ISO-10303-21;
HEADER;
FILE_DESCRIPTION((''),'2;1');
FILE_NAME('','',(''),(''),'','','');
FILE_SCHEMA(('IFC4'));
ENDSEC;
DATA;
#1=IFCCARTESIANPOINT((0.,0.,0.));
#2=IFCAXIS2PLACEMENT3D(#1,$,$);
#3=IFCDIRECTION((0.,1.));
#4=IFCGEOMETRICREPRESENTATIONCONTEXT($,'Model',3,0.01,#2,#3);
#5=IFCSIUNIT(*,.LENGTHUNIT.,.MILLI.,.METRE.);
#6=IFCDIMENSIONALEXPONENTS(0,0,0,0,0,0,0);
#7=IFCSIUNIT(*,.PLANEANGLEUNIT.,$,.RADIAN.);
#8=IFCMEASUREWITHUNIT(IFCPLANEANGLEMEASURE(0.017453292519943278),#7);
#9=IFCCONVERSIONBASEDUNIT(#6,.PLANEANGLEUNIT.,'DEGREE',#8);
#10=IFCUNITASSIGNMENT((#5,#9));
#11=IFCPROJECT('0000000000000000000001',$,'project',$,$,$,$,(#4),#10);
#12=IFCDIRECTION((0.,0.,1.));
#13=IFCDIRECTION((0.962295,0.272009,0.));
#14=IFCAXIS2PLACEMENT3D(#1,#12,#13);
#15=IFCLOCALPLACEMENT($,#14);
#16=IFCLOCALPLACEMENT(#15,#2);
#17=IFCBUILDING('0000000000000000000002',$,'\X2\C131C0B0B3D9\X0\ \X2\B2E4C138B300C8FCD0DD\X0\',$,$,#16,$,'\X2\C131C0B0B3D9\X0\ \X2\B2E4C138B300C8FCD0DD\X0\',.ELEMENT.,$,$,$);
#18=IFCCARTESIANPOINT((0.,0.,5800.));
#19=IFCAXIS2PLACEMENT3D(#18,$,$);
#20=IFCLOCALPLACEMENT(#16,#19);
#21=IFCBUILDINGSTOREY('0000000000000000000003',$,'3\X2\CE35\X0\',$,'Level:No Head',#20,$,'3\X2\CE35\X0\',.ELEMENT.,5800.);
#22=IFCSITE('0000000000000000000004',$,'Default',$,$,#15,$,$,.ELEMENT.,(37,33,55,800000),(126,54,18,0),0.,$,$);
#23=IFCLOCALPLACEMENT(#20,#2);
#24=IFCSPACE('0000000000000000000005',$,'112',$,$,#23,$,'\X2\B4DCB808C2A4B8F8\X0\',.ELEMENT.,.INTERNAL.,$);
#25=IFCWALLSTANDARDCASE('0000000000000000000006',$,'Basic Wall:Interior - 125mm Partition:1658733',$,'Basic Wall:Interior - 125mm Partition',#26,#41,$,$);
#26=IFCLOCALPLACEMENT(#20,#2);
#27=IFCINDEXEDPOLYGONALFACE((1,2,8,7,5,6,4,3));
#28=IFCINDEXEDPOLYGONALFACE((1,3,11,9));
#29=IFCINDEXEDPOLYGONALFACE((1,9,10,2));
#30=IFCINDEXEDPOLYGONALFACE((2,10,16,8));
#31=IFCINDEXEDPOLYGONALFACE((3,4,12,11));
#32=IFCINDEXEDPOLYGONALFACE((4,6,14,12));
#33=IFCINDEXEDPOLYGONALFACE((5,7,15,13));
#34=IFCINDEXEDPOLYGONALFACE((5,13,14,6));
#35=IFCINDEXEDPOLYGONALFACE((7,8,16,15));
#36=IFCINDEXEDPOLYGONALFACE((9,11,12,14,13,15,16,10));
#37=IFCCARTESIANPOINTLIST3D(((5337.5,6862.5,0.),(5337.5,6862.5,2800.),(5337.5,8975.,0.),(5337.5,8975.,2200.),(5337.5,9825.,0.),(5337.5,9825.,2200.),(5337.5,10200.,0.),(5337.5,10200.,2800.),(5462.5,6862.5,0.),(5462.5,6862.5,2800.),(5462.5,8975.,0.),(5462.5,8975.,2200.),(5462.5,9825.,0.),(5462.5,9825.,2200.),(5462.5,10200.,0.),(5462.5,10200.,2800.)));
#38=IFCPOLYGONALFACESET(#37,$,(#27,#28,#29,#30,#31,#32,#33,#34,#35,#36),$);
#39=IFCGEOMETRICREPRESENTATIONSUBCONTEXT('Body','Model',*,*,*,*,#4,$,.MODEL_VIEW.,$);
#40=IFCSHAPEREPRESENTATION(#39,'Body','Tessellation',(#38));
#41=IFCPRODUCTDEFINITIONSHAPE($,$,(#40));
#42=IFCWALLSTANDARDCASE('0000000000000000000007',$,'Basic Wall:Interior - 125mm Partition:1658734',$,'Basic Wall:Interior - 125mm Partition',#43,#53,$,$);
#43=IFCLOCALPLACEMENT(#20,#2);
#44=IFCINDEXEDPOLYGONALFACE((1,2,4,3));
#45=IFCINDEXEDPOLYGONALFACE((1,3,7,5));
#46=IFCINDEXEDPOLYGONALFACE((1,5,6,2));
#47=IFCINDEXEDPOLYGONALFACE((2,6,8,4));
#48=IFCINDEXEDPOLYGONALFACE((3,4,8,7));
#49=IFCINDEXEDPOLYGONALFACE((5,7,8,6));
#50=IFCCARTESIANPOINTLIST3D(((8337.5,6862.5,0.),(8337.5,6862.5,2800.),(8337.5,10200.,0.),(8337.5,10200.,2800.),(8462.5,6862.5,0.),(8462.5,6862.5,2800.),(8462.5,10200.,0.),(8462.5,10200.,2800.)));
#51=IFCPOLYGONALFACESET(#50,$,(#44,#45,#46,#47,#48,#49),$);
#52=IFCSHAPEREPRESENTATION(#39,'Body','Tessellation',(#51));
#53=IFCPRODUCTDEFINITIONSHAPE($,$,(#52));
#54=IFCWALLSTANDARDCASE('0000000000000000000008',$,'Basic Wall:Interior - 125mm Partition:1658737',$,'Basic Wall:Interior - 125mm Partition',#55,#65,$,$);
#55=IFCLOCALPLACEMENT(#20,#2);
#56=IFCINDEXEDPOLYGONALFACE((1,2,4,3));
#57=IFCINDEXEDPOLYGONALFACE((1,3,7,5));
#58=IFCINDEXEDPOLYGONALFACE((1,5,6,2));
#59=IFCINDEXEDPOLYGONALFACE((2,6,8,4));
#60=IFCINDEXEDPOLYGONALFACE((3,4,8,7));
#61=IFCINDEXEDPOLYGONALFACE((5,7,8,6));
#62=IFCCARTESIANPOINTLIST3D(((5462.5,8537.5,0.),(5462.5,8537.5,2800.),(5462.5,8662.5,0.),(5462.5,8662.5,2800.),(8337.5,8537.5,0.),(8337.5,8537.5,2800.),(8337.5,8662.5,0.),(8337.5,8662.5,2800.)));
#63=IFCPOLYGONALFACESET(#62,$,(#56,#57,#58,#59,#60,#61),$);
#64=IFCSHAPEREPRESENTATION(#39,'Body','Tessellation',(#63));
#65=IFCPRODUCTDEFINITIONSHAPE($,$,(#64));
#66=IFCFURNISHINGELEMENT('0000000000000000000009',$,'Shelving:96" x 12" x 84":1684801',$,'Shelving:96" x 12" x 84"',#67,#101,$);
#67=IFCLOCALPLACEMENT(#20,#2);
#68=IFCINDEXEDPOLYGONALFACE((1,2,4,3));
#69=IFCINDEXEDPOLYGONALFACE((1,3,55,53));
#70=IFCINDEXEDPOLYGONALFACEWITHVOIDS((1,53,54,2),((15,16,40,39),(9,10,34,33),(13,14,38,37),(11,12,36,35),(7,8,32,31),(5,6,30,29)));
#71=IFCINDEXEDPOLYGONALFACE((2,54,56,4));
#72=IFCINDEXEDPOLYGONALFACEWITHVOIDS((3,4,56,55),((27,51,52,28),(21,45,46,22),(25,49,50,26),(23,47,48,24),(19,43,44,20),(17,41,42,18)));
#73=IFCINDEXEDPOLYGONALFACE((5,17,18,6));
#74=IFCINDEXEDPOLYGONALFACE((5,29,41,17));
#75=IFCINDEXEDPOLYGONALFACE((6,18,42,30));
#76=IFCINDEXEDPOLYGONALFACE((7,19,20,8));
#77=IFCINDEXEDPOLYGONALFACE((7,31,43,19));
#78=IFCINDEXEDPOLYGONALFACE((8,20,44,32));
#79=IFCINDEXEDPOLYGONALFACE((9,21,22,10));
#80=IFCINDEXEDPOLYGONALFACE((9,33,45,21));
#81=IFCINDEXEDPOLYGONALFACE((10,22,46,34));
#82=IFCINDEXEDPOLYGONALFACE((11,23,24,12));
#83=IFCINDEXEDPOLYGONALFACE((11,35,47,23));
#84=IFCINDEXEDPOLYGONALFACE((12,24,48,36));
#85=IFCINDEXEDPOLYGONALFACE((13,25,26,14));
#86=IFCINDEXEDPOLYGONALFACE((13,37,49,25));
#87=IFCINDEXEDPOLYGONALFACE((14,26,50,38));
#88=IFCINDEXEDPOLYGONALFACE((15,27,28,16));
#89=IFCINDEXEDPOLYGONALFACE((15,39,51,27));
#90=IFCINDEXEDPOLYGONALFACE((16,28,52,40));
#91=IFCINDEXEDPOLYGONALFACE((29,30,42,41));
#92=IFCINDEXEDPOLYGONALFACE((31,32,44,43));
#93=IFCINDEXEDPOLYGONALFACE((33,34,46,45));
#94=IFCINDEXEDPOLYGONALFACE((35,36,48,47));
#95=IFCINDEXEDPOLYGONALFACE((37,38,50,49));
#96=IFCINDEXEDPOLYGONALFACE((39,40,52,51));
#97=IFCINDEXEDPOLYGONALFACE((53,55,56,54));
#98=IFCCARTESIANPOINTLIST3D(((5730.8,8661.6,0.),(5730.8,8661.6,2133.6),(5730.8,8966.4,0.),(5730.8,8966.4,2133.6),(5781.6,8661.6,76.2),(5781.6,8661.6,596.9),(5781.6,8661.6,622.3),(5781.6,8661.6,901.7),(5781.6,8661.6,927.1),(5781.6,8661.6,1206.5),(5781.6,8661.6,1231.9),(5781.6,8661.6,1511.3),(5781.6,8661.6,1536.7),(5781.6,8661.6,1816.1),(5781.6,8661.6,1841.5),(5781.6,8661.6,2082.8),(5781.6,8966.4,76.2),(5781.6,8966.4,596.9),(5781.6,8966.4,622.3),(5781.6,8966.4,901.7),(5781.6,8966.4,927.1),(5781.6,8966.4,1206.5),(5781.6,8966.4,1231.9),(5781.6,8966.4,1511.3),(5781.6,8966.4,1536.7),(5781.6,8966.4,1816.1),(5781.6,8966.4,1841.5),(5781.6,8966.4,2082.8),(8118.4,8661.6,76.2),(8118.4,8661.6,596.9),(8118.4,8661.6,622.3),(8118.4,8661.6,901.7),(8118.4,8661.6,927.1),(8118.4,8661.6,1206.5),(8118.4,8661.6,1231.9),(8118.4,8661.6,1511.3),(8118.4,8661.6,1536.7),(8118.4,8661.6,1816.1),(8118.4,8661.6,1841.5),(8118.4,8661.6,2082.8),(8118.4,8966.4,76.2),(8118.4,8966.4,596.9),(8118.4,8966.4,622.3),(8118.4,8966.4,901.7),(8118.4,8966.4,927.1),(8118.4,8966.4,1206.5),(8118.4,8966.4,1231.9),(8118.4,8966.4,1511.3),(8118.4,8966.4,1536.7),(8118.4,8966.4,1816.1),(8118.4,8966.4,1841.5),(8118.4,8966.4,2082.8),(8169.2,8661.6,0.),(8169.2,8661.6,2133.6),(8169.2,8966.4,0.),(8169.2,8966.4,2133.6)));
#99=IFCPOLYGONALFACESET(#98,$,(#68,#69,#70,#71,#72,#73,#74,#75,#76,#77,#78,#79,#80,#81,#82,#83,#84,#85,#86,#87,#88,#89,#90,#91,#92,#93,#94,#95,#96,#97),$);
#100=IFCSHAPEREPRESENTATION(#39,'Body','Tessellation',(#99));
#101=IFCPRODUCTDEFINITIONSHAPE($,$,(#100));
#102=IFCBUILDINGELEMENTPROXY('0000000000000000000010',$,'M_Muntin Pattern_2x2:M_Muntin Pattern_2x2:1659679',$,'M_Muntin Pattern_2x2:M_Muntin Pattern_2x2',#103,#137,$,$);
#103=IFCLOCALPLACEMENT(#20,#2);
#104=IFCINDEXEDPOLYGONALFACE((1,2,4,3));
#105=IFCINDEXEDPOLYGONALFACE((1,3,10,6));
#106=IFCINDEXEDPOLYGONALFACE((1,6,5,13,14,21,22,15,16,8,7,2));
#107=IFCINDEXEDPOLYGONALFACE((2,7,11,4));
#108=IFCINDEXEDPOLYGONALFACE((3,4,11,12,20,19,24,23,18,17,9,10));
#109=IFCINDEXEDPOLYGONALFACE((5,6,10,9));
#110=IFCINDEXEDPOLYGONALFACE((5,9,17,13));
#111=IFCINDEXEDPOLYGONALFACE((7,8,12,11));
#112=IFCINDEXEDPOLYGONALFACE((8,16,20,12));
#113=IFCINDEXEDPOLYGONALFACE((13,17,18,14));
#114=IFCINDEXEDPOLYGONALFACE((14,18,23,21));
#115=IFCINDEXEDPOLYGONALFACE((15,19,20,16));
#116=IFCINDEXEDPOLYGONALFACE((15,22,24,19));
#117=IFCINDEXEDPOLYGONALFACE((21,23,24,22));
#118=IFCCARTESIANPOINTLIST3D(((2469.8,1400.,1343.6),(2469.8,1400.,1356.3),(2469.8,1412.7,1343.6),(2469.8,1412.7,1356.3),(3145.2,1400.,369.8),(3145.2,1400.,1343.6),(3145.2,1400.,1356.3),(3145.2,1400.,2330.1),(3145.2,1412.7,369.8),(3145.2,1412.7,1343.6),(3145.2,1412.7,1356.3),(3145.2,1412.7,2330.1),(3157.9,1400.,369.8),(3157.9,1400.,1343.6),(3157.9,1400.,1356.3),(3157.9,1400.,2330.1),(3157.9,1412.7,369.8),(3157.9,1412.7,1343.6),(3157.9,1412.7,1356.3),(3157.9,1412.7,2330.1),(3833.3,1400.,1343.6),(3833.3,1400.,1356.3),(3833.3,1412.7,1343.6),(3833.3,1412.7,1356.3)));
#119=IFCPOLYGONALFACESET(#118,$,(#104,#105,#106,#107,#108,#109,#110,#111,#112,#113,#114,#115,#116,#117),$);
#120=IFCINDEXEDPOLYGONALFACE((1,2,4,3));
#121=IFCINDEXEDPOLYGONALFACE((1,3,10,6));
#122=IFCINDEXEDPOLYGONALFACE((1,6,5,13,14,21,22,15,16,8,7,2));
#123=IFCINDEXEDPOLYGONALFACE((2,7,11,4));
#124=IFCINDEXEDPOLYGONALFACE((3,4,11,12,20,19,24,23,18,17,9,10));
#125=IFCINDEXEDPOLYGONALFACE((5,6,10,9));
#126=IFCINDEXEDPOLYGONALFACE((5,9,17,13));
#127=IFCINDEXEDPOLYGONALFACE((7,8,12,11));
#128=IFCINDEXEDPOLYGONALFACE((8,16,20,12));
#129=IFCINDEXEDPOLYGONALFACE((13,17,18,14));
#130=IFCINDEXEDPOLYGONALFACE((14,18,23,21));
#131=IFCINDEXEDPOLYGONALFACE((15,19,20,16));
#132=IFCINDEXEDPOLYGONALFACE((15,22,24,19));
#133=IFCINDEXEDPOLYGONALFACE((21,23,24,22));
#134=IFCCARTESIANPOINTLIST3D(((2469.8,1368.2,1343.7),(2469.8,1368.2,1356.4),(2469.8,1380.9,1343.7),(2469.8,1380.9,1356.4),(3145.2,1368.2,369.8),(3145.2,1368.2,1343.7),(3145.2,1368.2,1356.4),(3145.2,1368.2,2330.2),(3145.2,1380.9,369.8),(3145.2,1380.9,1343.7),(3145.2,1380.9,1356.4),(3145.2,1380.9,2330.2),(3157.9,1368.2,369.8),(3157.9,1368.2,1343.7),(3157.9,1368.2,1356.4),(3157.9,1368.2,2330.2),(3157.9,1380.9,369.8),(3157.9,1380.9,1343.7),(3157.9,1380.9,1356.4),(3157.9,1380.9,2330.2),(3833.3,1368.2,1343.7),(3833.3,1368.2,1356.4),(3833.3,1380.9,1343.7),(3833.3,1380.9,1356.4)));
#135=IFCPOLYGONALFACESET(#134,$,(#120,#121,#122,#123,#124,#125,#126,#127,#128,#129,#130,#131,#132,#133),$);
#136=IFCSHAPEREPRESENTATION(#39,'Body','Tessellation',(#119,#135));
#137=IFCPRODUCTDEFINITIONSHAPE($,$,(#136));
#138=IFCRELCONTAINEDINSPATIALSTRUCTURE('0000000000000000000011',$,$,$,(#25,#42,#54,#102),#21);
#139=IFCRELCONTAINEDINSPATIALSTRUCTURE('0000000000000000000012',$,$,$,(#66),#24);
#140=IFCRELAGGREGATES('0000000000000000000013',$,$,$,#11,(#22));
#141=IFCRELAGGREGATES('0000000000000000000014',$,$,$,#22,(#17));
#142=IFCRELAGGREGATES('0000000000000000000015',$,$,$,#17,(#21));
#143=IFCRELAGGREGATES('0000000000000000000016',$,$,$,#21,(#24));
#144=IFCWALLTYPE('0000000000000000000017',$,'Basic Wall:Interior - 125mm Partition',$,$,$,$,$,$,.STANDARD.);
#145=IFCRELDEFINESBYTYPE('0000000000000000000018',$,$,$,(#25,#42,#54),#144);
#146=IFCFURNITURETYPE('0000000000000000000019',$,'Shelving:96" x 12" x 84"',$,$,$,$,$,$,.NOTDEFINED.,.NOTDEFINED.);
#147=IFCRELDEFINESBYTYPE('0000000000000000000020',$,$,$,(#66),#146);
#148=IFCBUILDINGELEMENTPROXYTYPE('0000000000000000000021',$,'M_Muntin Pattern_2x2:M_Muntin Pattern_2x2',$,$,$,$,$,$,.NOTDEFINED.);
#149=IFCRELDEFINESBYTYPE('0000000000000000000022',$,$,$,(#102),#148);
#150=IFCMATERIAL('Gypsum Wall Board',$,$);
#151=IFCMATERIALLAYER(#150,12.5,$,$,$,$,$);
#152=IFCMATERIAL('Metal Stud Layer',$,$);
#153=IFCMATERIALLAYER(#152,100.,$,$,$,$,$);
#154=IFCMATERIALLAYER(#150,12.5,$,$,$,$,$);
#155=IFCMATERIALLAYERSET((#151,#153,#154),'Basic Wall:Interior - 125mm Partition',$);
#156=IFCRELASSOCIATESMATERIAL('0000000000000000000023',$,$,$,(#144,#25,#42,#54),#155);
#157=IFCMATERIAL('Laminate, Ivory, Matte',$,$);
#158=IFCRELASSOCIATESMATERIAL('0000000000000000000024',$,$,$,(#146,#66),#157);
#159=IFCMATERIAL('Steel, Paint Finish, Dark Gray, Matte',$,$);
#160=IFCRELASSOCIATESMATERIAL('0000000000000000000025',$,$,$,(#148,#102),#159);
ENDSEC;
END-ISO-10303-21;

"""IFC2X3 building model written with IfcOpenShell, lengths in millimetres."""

from ifc_helpers import new_model, entity, si_unit, converted_unit, direction, frame, frame_2d, origin, place, context, subcontext, project, spatial, polyline, rectangle, outline, extrude, source, transform, mapped, material, layer, layer_set, layer_usage, type_object, type_shapes, element, save


model = new_model("IFC2X3")

# Units and contexts
model_context = context("Model", 3, precision=0.01, world=origin(), true_north=direction((0.0, 1.0)))
body_context = subcontext(model_context, "Body", "Model", "MODEL_VIEW")
ifc_project = project(units=[si_unit("LENGTHUNIT", "METRE", prefix="MILLI"), converted_unit("PLANEANGLEUNIT", "DEGREE", entity("IfcPlaneAngleMeasure", 0.017453292519943278), si_unit("PLANEANGLEUNIT", "RADIAN"), dimensions=[0, 0, 0, 0, 0, 0, 0])], contexts=[model_context])

# Site, building, storey
site_placement = place(None, frame((0.0, 0.0, 0.0), z_axis=(0.0, 0.0, 1.0), x_axis=(0.962295, 0.272009, 0.0)))
site = spatial("IfcSite", under=ifc_project, at=site_placement, Name="Default", CompositionType="ELEMENT", RefLatitude=(37, 33, 55, 800000), RefLongitude=(126, 54, 18, 0), RefElevation=0.0)
building_placement = place(site_placement, origin())
building = spatial("IfcBuilding", under=site, at=building_placement, Name="성산동 다세대주택", LongName="성산동 다세대주택", CompositionType="ELEMENT")
storey_placement = place(building_placement, frame((0.0, 0.0, 5800.0)))
storey = spatial("IfcBuildingStorey", under=building, at=storey_placement, Name="3층", ObjectType="Level:No Head", LongName="3층", CompositionType="ELEMENT", Elevation=5800.0)

# Wall, opening
ifc_material_1 = material(Name="Gypsum Wall Board")
ifc_layer_1 = layer(ifc_material_1, 12.5)
ifc_material_2 = material(Name="Metal Stud Layer")
ifc_layer_2 = layer(ifc_material_2, 100.0)
ifc_layer_3 = layer(ifc_material_1, 12.5)
ifc_layer_set = layer_set([ifc_layer_1, ifc_layer_2, ifc_layer_3], Name="Basic Wall:Interior - 125mm Partition")
ifc_layer_usage_1 = layer_usage(ifc_layer_set, "AXIS2", "NEGATIVE", 62.5)
wall_type = type_object("IfcWallType", Name="Basic Wall:Interior - 125mm Partition", PredefinedType="STANDARD", material=ifc_layer_set)
wall_1_placement = place(storey_placement, frame((5400.0, 6862.5, 0.0), z_axis=(0.0, 0.0, 1.0), x_axis=(0.0, 1.0, 0.0)))
wall_1 = element("IfcWallStandardCase", 1, at=wall_1_placement, inside=storey, type_object=wall_type, material=ifc_layer_usage_1, Name="Basic Wall:Interior - 125mm Partition:1658733", ObjectType="Basic Wall:Interior - 125mm Partition", context=body_context, shape_type="SweptSolid", body=[
    extrude(rectangle(XDim=3337.5, YDim=125.0, at=frame_2d((1668.7, 0.0), x_axis=(1.0, 0.0))), origin(), (0.0, 0.0, 1.0), 2800.0),
])
opening_placement = place(wall_1_placement, frame((2112.5, -62.5, 0.0)))
element("IfcOpeningElement", 2, at=opening_placement, cuts=wall_1, ObjectType="Opening", context=body_context, shape_type="SweptSolid", body=[
    extrude(rectangle(XDim=2200.0, YDim=850.0, at=frame_2d((1100.0, 425.0), x_axis=(1.0, 0.0))), frame((0.0, 0.0, 0.0), z_axis=(0.0, 1.0, 0.0), x_axis=(0.0, 0.0, 1.0)), (0.0, 0.0, 1.0), 125.0),
])

# Walls
ifc_layer_usage_2 = layer_usage(ifc_layer_set, "AXIS2", "NEGATIVE", 62.5)
wall_2_placement = place(storey_placement, frame((8400.0, 6862.5, 0.0), z_axis=(0.0, 0.0, 1.0), x_axis=(0.0, 1.0, 0.0)))
element("IfcWallStandardCase", 3, at=wall_2_placement, inside=storey, type_object=wall_type, material=ifc_layer_usage_2, Name="Basic Wall:Interior - 125mm Partition:1658734", ObjectType="Basic Wall:Interior - 125mm Partition", context=body_context, shape_type="SweptSolid", body=[
    extrude(rectangle(XDim=3337.5, YDim=125.0, at=frame_2d((1668.7, 0.0), x_axis=(-1.0, 0.0))), origin(), (0.0, 0.0, 1.0), 2800.0),
])
ifc_layer_usage_3 = layer_usage(ifc_layer_set, "AXIS2", "NEGATIVE", 62.5)
wall_3_placement = place(storey_placement, frame((5462.5, 8600.0, 0.0)))
element("IfcWallStandardCase", 4, at=wall_3_placement, inside=storey, type_object=wall_type, material=ifc_layer_usage_3, Name="Basic Wall:Interior - 125mm Partition:1658737", ObjectType="Basic Wall:Interior - 125mm Partition", context=body_context, shape_type="SweptSolid", body=[
    extrude(rectangle(XDim=2875.0, YDim=125.0, at=frame_2d((1437.5, 0.0), x_axis=(-1.0, 0.0))), origin(), (0.0, 0.0, 1.0), 2800.0),
])

# Shared definitions
space_1_placement = place(storey_placement, origin())
space_1 = spatial("IfcSpace", under=storey, at=space_1_placement, Name="112", LongName="드레스룸", CompositionType="ELEMENT", InteriorOrExteriorSpace="INTERNAL")

# Furnishing element
ifc_material_3 = material(Name="Laminate, Ivory, Matte")
furniture_type_1 = type_object("IfcFurnitureType", Name="Shelving:96\" x 12\" x 84\"", AssemblyPlace="NOTDEFINED", material=ifc_material_3)
shared_shape_1 = source(origin(), body_context, "Body", "SweptSolid", [
    extrude(outline(polyline([(-1219.2, -1066.8), (1219.2, -1066.8), (1219.2, 1066.8), (-1219.2, 1066.8), (-1219.2, -1066.8)]), holes=[polyline([(-1168.4, 1016.0), (1168.4, 1016.0), (1168.4, 774.7), (-1168.4, 774.7), (-1168.4, 1016.0)]), polyline([(-1168.4, -990.6), (-1168.4, -469.9), (1168.4, -469.9), (1168.4, -990.6), (-1168.4, -990.6)]), polyline([(1168.4, 165.1), (-1168.4, 165.1), (-1168.4, 444.5), (1168.4, 444.5), (1168.4, 165.1)]), polyline([(-1168.4, 749.3), (1168.4, 749.3), (1168.4, 469.9), (-1168.4, 469.9), (-1168.4, 749.3)]), polyline([(-1168.4, 139.7), (1168.4, 139.7), (1168.4, -139.7), (-1168.4, -139.7), (-1168.4, 139.7)]), polyline([(-1168.4, -165.1), (1168.4, -165.1), (1168.4, -444.5), (-1168.4, -444.5), (-1168.4, -165.1)])]), frame((0.0, -457.2, 1066.8), z_axis=(0.0, 1.0, 0.0), x_axis=(-1.0, 0.0, 0.0)), (0.0, 0.0, 1.0), 304.8),
])
type_shapes(furniture_type_1, [shared_shape_1])
furnishing_1_placement = place(space_1_placement, frame((6950.0, 8509.2, 0.0), z_axis=(0.0, 0.0, 1.0), x_axis=(-1.0, 0.0, 0.0)))
element("IfcFurnishingElement", 5, at=furnishing_1_placement, inside=space_1, type_object=furniture_type_1, material=ifc_material_3, Name="Shelving:96\" x 12\" x 84\":1684801", ObjectType="Shelving:96\" x 12\" x 84\"", context=body_context, shape_type="MappedRepresentation", body=[
    mapped(shared_shape_1, transform((0.0, 0.0, 0.0), scale=1.0)),
])

# Building element proxy
ifc_material_4 = material(Name="Steel, Paint Finish, Dark Gray, Matte")
building_element_proxy_type_1 = type_object("IfcBuildingElementProxyType", Name="M_Muntin Pattern_2x2:M_Muntin Pattern_2x2", PredefinedType="NOTDEFINED", material=ifc_material_4)
shared_shape_2 = source(origin(), body_context, "Body", "SweptSolid", [
    extrude(outline(polyline([(6.4, -6.4), (980.1, -6.4), (980.1, 6.3), (6.4, 6.3), (6.4, 681.7), (-6.3, 681.7), (-6.3, 6.3), (-980.2, 6.3), (-980.2, -6.4), (-6.3, -6.4), (-6.3, -681.7), (6.4, -681.7), (6.4, -6.4)])), frame((0.0, 9.5, 980.1), z_axis=(0.0, 1.0, 0.0), x_axis=(0.0, 0.0, 1.0)), (0.0, 0.0, 1.0), 12.7),
    extrude(outline(polyline([(6.4, -6.4), (980.2, -6.4), (980.2, 6.3), (6.4, 6.3), (6.4, 681.7), (-6.3, 681.7), (-6.3, 6.3), (-980.2, 6.3), (-980.2, -6.4), (-6.3, -6.4), (-6.3, -681.7), (6.4, -681.7), (6.4, -6.4)])), frame((0.0, -22.2, 980.2), z_axis=(0.0, 1.0, 0.0), x_axis=(0.0, 0.0, 1.0)), (0.0, 0.0, 1.0), 12.7),
])
type_shapes(building_element_proxy_type_1, [shared_shape_2])
proxy_1_placement = place(storey_placement, frame((3151.6, 1390.5, 369.8)))
element("IfcBuildingElementProxy", 6, at=proxy_1_placement, inside=storey, type_object=building_element_proxy_type_1, material=ifc_material_4, Name="M_Muntin Pattern_2x2:M_Muntin Pattern_2x2:1659679", ObjectType="M_Muntin Pattern_2x2:M_Muntin Pattern_2x2", context=body_context, shape_type="MappedRepresentation", body=[
    mapped(shared_shape_2, transform((0.0, 0.0, 0.0), scale=1.0)),
])

save(model, "model.ifc")
